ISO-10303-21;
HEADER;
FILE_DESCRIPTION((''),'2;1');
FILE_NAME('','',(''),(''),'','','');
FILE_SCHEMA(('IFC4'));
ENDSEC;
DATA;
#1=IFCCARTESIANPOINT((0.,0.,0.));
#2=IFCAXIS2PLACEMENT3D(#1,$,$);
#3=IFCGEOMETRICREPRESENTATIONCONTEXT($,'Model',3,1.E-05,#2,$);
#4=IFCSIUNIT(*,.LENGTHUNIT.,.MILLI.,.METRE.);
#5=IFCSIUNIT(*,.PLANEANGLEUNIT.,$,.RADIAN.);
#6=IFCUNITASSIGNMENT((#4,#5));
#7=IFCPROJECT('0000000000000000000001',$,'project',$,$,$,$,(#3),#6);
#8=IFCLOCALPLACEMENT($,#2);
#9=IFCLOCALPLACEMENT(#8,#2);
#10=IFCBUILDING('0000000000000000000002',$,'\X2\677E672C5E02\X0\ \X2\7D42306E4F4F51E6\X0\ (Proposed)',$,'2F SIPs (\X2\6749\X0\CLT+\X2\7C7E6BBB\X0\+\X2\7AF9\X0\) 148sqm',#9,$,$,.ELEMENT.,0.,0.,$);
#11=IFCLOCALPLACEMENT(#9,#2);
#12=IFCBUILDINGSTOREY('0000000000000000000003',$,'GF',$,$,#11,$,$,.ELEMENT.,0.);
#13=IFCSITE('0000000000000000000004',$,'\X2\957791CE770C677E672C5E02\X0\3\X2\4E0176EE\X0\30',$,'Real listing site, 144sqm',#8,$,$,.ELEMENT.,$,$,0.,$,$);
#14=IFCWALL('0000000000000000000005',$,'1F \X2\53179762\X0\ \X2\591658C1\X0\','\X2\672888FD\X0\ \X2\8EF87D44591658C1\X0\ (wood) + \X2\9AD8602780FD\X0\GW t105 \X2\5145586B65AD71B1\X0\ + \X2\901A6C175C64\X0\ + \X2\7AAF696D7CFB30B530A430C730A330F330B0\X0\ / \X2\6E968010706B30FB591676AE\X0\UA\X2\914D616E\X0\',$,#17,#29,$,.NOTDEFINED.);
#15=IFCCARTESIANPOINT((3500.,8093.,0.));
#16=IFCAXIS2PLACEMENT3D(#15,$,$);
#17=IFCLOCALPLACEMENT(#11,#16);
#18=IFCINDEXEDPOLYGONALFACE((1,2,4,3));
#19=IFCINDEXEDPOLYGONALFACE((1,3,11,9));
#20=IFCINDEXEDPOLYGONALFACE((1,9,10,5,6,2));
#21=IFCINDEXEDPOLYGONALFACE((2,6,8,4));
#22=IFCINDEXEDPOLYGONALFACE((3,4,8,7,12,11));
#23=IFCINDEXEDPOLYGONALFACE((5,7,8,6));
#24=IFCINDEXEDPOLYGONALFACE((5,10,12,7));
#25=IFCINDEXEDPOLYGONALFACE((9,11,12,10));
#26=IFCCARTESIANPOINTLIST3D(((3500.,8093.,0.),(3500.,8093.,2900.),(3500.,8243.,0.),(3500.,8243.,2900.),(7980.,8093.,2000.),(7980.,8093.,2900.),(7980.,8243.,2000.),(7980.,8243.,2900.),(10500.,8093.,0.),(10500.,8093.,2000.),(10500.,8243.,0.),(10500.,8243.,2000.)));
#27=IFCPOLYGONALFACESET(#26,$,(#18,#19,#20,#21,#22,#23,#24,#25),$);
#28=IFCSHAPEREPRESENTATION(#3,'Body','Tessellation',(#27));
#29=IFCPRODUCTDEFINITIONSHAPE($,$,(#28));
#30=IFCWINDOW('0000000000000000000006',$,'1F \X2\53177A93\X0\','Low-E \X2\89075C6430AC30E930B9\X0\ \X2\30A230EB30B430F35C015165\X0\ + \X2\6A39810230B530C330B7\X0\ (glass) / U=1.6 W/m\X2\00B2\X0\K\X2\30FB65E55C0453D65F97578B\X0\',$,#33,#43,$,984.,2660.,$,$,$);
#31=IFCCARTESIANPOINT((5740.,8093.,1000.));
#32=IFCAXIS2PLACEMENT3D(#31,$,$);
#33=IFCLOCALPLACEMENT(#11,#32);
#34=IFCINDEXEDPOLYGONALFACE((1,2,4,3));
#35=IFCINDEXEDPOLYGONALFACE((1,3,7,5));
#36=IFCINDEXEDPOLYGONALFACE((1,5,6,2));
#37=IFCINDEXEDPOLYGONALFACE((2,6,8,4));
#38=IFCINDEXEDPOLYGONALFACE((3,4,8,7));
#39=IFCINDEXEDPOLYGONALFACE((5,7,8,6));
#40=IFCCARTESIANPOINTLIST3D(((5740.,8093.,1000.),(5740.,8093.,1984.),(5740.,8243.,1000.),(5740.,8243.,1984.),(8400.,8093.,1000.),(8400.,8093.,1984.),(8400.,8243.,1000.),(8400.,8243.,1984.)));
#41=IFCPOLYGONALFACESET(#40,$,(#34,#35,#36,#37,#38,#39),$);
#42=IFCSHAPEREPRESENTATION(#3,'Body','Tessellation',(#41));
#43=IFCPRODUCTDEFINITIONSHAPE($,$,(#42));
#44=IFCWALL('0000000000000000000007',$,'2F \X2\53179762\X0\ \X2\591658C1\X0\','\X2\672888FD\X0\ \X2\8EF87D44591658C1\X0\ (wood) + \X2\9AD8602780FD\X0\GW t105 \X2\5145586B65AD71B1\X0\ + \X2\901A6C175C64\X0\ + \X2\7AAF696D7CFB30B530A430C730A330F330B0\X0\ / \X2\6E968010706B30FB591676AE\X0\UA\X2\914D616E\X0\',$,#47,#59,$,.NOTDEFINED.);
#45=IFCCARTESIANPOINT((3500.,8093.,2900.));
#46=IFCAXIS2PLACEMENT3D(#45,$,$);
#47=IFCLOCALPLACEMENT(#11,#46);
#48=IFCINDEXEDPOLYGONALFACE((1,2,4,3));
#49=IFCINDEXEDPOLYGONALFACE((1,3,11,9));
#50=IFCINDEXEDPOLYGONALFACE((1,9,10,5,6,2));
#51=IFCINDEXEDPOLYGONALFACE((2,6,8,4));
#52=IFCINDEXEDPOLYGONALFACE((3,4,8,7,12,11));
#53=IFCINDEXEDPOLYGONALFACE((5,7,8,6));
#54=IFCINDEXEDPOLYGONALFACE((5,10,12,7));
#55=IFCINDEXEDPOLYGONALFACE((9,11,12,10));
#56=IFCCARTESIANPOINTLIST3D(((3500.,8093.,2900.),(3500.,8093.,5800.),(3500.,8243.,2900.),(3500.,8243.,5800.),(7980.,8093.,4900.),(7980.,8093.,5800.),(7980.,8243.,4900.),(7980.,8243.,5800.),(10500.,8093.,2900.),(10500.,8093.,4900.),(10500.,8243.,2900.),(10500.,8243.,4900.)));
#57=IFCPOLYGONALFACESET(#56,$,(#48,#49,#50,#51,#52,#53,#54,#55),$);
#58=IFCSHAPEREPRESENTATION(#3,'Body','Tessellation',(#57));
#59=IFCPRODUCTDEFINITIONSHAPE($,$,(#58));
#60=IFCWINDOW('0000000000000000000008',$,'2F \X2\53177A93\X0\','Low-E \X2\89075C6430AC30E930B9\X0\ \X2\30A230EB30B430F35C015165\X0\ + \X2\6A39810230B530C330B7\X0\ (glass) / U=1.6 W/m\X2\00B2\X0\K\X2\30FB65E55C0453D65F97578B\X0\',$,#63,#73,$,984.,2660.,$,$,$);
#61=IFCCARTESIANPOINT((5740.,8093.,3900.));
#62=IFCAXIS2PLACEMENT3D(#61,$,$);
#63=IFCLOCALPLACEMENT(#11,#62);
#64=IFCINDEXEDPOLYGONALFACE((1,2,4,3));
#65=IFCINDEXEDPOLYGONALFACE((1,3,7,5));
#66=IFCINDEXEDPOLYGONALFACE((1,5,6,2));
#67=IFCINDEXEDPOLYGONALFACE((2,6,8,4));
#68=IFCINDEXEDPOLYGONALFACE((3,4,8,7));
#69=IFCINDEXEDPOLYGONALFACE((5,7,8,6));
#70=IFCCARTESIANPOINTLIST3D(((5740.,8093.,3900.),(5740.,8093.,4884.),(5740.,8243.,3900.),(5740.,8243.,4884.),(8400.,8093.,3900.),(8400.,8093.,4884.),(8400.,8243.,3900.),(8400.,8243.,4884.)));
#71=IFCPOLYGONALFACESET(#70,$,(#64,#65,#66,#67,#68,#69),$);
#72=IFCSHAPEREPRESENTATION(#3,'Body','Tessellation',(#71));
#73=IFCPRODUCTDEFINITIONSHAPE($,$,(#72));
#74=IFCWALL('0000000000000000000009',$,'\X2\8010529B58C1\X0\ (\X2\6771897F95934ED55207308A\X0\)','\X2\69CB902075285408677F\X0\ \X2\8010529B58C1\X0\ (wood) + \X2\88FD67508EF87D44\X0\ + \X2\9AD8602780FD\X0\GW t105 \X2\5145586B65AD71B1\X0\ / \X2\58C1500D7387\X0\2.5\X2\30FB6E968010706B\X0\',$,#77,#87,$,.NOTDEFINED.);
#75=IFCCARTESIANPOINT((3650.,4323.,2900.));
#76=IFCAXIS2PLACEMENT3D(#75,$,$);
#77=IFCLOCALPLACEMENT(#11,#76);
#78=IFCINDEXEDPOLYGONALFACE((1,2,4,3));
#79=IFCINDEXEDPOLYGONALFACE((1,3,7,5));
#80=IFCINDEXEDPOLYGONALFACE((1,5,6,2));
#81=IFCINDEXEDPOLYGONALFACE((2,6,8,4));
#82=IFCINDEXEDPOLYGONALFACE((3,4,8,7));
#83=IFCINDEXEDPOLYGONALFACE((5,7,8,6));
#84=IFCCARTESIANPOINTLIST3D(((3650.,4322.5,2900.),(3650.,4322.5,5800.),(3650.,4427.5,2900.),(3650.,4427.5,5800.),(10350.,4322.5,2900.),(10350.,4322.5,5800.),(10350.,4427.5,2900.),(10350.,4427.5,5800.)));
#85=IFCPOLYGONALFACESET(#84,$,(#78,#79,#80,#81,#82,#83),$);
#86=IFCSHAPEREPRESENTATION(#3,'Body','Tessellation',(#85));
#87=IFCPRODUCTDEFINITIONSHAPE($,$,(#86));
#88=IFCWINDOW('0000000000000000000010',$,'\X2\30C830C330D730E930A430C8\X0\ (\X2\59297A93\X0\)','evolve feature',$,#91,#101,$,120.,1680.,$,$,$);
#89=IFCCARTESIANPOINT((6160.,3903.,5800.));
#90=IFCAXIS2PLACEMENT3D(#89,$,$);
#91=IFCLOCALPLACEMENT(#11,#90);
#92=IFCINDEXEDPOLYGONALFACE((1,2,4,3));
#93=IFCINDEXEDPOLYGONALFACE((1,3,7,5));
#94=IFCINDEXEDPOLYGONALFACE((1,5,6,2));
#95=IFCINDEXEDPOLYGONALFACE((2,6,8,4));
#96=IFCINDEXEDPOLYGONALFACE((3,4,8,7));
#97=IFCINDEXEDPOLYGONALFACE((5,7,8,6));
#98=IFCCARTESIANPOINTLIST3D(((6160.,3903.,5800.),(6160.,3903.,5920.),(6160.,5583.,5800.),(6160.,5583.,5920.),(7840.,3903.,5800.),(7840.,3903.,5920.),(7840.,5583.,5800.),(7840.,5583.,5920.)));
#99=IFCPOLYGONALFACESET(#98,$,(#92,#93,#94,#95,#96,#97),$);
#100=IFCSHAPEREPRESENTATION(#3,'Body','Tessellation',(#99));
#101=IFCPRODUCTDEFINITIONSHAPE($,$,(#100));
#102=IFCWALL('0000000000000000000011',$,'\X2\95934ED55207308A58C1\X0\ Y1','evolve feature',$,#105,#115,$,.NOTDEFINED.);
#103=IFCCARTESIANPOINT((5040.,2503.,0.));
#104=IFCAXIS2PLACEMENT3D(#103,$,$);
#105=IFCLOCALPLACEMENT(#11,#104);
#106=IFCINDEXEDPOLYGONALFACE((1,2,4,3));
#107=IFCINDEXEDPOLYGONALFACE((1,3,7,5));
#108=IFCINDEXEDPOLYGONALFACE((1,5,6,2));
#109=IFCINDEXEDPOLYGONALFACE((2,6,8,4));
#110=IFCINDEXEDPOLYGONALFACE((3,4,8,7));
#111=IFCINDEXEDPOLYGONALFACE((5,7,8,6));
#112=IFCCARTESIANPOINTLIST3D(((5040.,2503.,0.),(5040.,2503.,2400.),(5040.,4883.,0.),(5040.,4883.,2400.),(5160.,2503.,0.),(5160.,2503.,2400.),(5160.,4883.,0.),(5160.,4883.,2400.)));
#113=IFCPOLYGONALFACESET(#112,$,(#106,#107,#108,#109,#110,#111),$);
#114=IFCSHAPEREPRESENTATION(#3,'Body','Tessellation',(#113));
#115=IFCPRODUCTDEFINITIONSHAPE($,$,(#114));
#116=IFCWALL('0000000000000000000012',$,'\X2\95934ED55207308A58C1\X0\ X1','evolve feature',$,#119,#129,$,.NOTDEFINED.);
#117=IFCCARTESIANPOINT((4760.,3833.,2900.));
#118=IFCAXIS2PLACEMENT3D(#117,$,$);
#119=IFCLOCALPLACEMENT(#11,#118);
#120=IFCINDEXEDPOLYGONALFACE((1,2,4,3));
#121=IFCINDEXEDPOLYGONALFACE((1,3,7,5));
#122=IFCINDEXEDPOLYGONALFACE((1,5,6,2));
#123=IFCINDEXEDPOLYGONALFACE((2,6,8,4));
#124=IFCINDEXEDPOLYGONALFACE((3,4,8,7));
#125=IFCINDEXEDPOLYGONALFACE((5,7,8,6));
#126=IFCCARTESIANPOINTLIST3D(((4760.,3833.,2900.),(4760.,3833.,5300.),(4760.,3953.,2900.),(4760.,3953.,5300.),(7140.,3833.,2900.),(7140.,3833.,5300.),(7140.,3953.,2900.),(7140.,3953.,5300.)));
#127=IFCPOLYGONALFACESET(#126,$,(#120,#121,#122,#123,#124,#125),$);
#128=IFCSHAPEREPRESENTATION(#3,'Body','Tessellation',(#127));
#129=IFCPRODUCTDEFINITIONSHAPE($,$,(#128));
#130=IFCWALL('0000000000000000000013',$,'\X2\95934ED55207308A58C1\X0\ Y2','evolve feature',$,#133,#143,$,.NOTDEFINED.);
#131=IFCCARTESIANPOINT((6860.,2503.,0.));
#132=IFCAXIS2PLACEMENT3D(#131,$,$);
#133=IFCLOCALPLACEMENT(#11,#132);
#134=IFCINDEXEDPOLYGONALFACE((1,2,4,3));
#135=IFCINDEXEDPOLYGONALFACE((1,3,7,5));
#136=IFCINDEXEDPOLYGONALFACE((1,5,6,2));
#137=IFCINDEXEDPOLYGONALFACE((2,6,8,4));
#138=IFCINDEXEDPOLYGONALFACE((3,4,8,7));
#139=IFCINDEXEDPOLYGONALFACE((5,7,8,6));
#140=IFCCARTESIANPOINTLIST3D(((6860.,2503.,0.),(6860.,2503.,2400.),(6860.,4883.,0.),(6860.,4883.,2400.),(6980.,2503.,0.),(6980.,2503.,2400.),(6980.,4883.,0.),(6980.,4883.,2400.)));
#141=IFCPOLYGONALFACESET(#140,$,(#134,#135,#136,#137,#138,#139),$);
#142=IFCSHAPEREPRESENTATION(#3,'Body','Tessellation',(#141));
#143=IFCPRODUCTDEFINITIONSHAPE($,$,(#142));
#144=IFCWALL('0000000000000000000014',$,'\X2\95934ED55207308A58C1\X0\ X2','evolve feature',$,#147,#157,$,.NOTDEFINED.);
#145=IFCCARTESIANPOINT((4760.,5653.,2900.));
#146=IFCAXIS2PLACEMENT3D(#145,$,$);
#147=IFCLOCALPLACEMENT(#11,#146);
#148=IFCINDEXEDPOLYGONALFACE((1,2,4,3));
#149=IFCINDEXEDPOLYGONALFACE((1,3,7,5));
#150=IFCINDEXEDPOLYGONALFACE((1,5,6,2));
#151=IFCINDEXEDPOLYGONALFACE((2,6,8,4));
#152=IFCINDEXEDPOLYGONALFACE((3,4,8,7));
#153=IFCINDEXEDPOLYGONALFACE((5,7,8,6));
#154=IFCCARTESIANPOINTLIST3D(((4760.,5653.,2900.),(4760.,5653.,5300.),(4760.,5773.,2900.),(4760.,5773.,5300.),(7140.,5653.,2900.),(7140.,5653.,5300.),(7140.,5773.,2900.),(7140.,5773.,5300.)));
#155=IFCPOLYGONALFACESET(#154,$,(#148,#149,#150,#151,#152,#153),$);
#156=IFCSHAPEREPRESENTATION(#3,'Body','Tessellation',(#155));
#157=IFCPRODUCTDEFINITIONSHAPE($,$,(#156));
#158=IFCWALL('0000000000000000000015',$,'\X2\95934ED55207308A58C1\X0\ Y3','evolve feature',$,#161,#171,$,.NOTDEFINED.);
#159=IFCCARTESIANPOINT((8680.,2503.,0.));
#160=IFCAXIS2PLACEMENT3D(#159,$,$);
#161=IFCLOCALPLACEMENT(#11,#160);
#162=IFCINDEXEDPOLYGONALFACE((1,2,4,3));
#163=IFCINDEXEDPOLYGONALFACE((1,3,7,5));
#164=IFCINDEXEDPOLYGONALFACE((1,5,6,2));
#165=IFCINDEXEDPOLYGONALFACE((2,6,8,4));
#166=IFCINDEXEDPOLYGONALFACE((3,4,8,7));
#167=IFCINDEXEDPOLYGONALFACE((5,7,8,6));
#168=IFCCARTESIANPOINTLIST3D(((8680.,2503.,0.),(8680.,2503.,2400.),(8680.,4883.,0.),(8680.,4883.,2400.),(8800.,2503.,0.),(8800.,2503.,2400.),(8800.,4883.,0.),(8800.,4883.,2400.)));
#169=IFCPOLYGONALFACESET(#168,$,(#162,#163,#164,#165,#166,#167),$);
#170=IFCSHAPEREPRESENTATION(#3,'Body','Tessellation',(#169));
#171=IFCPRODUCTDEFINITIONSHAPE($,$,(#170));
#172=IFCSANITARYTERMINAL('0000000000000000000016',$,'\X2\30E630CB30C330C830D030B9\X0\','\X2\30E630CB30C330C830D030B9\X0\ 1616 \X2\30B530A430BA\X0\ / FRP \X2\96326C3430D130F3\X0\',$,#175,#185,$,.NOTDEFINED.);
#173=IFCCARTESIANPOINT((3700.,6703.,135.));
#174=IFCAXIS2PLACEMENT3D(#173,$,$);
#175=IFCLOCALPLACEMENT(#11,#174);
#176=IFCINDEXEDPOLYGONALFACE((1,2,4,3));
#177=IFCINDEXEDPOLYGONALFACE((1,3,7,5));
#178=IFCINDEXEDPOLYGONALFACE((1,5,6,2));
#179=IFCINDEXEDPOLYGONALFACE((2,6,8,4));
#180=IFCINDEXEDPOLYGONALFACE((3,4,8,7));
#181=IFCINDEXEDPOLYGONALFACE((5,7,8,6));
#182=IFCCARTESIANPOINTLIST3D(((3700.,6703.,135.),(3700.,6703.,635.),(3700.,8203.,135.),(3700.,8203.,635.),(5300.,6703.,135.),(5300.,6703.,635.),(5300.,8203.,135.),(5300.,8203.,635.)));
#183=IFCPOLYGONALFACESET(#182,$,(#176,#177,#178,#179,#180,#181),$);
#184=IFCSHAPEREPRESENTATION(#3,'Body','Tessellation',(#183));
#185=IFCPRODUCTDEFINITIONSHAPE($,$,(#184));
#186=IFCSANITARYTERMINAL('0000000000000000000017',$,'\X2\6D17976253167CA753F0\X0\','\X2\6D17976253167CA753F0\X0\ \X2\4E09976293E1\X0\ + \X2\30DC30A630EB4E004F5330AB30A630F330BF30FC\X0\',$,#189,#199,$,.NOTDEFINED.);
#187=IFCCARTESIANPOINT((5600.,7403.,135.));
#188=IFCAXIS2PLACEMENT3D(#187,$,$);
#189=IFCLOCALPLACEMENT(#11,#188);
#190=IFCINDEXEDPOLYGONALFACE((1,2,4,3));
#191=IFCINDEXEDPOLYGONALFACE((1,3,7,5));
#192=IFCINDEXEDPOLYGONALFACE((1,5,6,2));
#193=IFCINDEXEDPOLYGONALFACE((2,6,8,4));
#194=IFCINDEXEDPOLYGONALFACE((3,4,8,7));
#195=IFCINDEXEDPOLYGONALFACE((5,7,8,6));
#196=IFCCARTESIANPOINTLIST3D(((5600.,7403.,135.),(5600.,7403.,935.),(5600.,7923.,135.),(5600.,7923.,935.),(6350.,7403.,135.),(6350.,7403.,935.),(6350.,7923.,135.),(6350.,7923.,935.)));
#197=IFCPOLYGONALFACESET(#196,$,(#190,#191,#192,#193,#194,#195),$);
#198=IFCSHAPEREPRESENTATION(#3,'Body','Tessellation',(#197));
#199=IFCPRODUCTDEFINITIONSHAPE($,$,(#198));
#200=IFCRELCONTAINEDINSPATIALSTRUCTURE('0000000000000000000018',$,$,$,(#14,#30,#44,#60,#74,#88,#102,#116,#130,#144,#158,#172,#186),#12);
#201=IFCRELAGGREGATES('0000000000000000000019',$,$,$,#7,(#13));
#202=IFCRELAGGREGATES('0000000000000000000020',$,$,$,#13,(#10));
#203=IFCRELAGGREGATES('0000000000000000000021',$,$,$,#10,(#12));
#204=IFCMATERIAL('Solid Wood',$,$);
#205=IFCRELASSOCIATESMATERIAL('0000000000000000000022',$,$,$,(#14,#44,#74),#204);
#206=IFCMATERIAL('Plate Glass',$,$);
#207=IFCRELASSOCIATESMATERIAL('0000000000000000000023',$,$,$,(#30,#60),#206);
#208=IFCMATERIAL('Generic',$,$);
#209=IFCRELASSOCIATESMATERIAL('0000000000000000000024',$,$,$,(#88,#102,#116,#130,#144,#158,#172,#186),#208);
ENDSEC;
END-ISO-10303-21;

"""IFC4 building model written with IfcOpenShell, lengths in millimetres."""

from ifc_helpers import new_model, si_unit, frame, frame_2d, origin, place, context, project, spatial, rectangle, extrude, material, element, fill, save


model = new_model("IFC4")

# Units and contexts
model_context = context("Model", 3, precision=1e-05, world=origin())
ifc_project = project(units=[si_unit("LENGTHUNIT", "METRE", prefix="MILLI"), si_unit("PLANEANGLEUNIT", "RADIAN")], contexts=[model_context])

# Site, building, storey
site_placement = place(None, origin())
site = spatial("IfcSite", under=ifc_project, at=site_placement, Name="長野県松本市3丁目30", ObjectType="Real listing site, 144sqm", CompositionType="ELEMENT", RefElevation=0.0)
building_placement = place(site_placement, origin())
building = spatial("IfcBuilding", under=site, at=building_placement, Name="松本市 終の住処 (Proposed)", ObjectType="2F SIPs (杉CLT+籾殻+竹) 148sqm", CompositionType="ELEMENT", ElevationOfRefHeight=0.0, ElevationOfTerrain=0.0)
storey_placement = place(building_placement, origin())
storey = spatial("IfcBuildingStorey", under=building, at=storey_placement, Name="GF", CompositionType="ELEMENT", Elevation=0.0)

# Wall, opening, window
ifc_material_1 = material(Name="Solid Wood")
wall_1_placement = place(storey_placement, frame((3500.0, 8093.0, 0.0)))
wall_1 = element("IfcWall", 1, at=wall_1_placement, inside=storey, material=ifc_material_1, Name="1F 北面 外壁", Description="木製 軸組外壁 (wood) + 高性能GW t105 充填断熱 + 通気層 + 窯業系サイディング / 準耐火・外皮UA配慮", PredefinedType="NOTDEFINED", context=model_context, shape_type="SweptSolid", body=[
    extrude(rectangle(XDim=7000.0, YDim=150.0, at=frame_2d((3500.0, 75.0))), frame((3500.0, 8093.0, 0.0)), (0.0, 0.0, 1.0), 2900.0),
])
opening_1_placement = place(storey_placement, frame((5740.0, 8093.0, 1000.0)))
opening_1 = element("IfcOpeningElement", 2, at=opening_1_placement, cuts=wall_1, PredefinedType="NOTDEFINED", context=model_context, shape_type="SweptSolid", body=[
    extrude(rectangle(XDim=2660.0, YDim=150.0, at=frame_2d((1330.0, 75.0))), frame((5740.0, 8093.0, 1000.0)), (0.0, 0.0, 1.0), 984.0),
])
ifc_material_2 = material(Name="Plate Glass")
window_1_placement = place(storey_placement, frame((5740.0, 8093.0, 1000.0)))
window_1 = element("IfcWindow", 3, at=window_1_placement, inside=storey, material=ifc_material_2, Name="1F 北窓", Description="Low-E 複層ガラス アルゴン封入 + 樹脂サッシ (glass) / U=1.6 W/m²K・日射取得型", OverallHeight=984.0, OverallWidth=2660.0, context=model_context, shape_type="SweptSolid", body=[
    extrude(rectangle(XDim=2660.0, YDim=150.0, at=frame_2d((1330.0, 75.0))), frame((5740.0, 8093.0, 1000.0)), (0.0, 0.0, 1.0), 984.0),
])
fill(opening_1, window_1)

# Wall, opening, window
wall_2_placement = place(storey_placement, frame((3500.0, 8093.0, 2900.0)))
wall_2 = element("IfcWall", 4, at=wall_2_placement, inside=storey, material=ifc_material_1, Name="2F 北面 外壁", Description="木製 軸組外壁 (wood) + 高性能GW t105 充填断熱 + 通気層 + 窯業系サイディング / 準耐火・外皮UA配慮", PredefinedType="NOTDEFINED", context=model_context, shape_type="SweptSolid", body=[
    extrude(rectangle(XDim=7000.0, YDim=150.0, at=frame_2d((3500.0, 75.0))), frame((3500.0, 8093.0, 2900.0)), (0.0, 0.0, 1.0), 2900.0),
])
opening_2_placement = place(storey_placement, frame((5740.0, 8093.0, 3900.0)))
opening_2 = element("IfcOpeningElement", 5, at=opening_2_placement, cuts=wall_2, PredefinedType="NOTDEFINED", context=model_context, shape_type="SweptSolid", body=[
    extrude(rectangle(XDim=2660.0, YDim=150.0, at=frame_2d((1330.0, 75.0))), frame((5740.0, 8093.0, 3900.0)), (0.0, 0.0, 1.0), 984.0),
])
window_2_placement = place(storey_placement, frame((5740.0, 8093.0, 3900.0)))
window_2 = element("IfcWindow", 6, at=window_2_placement, inside=storey, material=ifc_material_2, Name="2F 北窓", Description="Low-E 複層ガラス アルゴン封入 + 樹脂サッシ (glass) / U=1.6 W/m²K・日射取得型", OverallHeight=984.0, OverallWidth=2660.0, context=model_context, shape_type="SweptSolid", body=[
    extrude(rectangle(XDim=2660.0, YDim=150.0, at=frame_2d((1330.0, 75.0))), frame((5740.0, 8093.0, 3900.0)), (0.0, 0.0, 1.0), 984.0),
])
fill(opening_2, window_2)

# Wall
wall_3_placement = place(storey_placement, frame((3650.0, 4323.0, 2900.0)))
element("IfcWall", 7, at=wall_3_placement, inside=storey, material=ifc_material_1, Name="耐力壁 (東西間仕切り)", Description="構造用合板 耐力壁 (wood) + 製材軸組 + 高性能GW t105 充填断熱 / 壁倍率2.5・準耐火", PredefinedType="NOTDEFINED", context=model_context, shape_type="SweptSolid", body=[
    extrude(rectangle(XDim=6700.0, YDim=105.0, at=frame_2d((3350.0, 52.0))), frame((3650.0, 4323.0, 2900.0)), (0.0, 0.0, 1.0), 2900.0),
])

# Window
ifc_material_3 = material(Name="Generic")
window_3_placement = place(storey_placement, frame((6160.0, 3903.0, 5800.0)))
element("IfcWindow", 8, at=window_3_placement, inside=storey, material=ifc_material_3, Name="トップライト (天窓)", Description="evolve feature", OverallHeight=120.0, OverallWidth=1680.0, context=model_context, shape_type="SweptSolid", body=[
    extrude(rectangle(XDim=1680.0, YDim=1680.0, at=frame_2d((840.0, 840.0))), frame((6160.0, 3903.0, 5800.0)), (0.0, 0.0, 1.0), 120.0),
])

# Walls
wall_4_placement = place(storey_placement, frame((5040.0, 2503.0, 0.0)))
element("IfcWall", 9, at=wall_4_placement, inside=storey, material=ifc_material_3, Name="間仕切り壁 Y1", Description="evolve feature", PredefinedType="NOTDEFINED", context=model_context, shape_type="SweptSolid", body=[
    extrude(rectangle(XDim=120.0, YDim=2380.0, at=frame_2d((60.0, 1190.0))), frame((5040.0, 2503.0, 0.0)), (0.0, 0.0, 1.0), 2400.0),
])
wall_5_placement = place(storey_placement, frame((4760.0, 3833.0, 2900.0)))
element("IfcWall", 10, at=wall_5_placement, inside=storey, material=ifc_material_3, Name="間仕切り壁 X1", Description="evolve feature", PredefinedType="NOTDEFINED", context=model_context, shape_type="SweptSolid", body=[
    extrude(rectangle(XDim=2380.0, YDim=120.0, at=frame_2d((1190.0, 60.0))), frame((4760.0, 3833.0, 2900.0)), (0.0, 0.0, 1.0), 2400.0),
])
wall_6_placement = place(storey_placement, frame((6860.0, 2503.0, 0.0)))
element("IfcWall", 11, at=wall_6_placement, inside=storey, material=ifc_material_3, Name="間仕切り壁 Y2", Description="evolve feature", PredefinedType="NOTDEFINED", context=model_context, shape_type="SweptSolid", body=[
    extrude(rectangle(XDim=120.0, YDim=2380.0, at=frame_2d((60.0, 1190.0))), frame((6860.0, 2503.0, 0.0)), (0.0, 0.0, 1.0), 2400.0),
])
wall_7_placement = place(storey_placement, frame((4760.0, 5653.0, 2900.0)))
element("IfcWall", 12, at=wall_7_placement, inside=storey, material=ifc_material_3, Name="間仕切り壁 X2", Description="evolve feature", PredefinedType="NOTDEFINED", context=model_context, shape_type="SweptSolid", body=[
    extrude(rectangle(XDim=2380.0, YDim=120.0, at=frame_2d((1190.0, 60.0))), frame((4760.0, 5653.0, 2900.0)), (0.0, 0.0, 1.0), 2400.0),
])
wall_8_placement = place(storey_placement, frame((8680.0, 2503.0, 0.0)))
element("IfcWall", 13, at=wall_8_placement, inside=storey, material=ifc_material_3, Name="間仕切り壁 Y3", Description="evolve feature", PredefinedType="NOTDEFINED", context=model_context, shape_type="SweptSolid", body=[
    extrude(rectangle(XDim=120.0, YDim=2380.0, at=frame_2d((60.0, 1190.0))), frame((8680.0, 2503.0, 0.0)), (0.0, 0.0, 1.0), 2400.0),
])

# Sanitary terminals
sanitary_terminal_1_placement = place(storey_placement, frame((3700.0, 6703.0, 135.0)))
element("IfcSanitaryTerminal", 14, at=sanitary_terminal_1_placement, inside=storey, material=ifc_material_3, Name="ユニットバス", Description="ユニットバス 1616 サイズ / FRP 防水パン", PredefinedType="NOTDEFINED", context=model_context, shape_type="SweptSolid", body=[
    extrude(rectangle(XDim=1600.0, YDim=1500.0, at=frame_2d((800.0, 750.0))), frame((3700.0, 6703.0, 135.0)), (0.0, 0.0, 1.0), 500.0),
])
sanitary_terminal_2_placement = place(storey_placement, frame((5600.0, 7403.0, 135.0)))
element("IfcSanitaryTerminal", 15, at=sanitary_terminal_2_placement, inside=storey, material=ifc_material_3, Name="洗面化粧台", Description="洗面化粧台 三面鏡 + ボウル一体カウンター", PredefinedType="NOTDEFINED", context=model_context, shape_type="SweptSolid", body=[
    extrude(rectangle(XDim=750.0, YDim=520.0, at=frame_2d((375.0, 260.0))), frame((5600.0, 7403.0, 135.0)), (0.0, 0.0, 1.0), 800.0),
])

save(model, "model.ifc")
